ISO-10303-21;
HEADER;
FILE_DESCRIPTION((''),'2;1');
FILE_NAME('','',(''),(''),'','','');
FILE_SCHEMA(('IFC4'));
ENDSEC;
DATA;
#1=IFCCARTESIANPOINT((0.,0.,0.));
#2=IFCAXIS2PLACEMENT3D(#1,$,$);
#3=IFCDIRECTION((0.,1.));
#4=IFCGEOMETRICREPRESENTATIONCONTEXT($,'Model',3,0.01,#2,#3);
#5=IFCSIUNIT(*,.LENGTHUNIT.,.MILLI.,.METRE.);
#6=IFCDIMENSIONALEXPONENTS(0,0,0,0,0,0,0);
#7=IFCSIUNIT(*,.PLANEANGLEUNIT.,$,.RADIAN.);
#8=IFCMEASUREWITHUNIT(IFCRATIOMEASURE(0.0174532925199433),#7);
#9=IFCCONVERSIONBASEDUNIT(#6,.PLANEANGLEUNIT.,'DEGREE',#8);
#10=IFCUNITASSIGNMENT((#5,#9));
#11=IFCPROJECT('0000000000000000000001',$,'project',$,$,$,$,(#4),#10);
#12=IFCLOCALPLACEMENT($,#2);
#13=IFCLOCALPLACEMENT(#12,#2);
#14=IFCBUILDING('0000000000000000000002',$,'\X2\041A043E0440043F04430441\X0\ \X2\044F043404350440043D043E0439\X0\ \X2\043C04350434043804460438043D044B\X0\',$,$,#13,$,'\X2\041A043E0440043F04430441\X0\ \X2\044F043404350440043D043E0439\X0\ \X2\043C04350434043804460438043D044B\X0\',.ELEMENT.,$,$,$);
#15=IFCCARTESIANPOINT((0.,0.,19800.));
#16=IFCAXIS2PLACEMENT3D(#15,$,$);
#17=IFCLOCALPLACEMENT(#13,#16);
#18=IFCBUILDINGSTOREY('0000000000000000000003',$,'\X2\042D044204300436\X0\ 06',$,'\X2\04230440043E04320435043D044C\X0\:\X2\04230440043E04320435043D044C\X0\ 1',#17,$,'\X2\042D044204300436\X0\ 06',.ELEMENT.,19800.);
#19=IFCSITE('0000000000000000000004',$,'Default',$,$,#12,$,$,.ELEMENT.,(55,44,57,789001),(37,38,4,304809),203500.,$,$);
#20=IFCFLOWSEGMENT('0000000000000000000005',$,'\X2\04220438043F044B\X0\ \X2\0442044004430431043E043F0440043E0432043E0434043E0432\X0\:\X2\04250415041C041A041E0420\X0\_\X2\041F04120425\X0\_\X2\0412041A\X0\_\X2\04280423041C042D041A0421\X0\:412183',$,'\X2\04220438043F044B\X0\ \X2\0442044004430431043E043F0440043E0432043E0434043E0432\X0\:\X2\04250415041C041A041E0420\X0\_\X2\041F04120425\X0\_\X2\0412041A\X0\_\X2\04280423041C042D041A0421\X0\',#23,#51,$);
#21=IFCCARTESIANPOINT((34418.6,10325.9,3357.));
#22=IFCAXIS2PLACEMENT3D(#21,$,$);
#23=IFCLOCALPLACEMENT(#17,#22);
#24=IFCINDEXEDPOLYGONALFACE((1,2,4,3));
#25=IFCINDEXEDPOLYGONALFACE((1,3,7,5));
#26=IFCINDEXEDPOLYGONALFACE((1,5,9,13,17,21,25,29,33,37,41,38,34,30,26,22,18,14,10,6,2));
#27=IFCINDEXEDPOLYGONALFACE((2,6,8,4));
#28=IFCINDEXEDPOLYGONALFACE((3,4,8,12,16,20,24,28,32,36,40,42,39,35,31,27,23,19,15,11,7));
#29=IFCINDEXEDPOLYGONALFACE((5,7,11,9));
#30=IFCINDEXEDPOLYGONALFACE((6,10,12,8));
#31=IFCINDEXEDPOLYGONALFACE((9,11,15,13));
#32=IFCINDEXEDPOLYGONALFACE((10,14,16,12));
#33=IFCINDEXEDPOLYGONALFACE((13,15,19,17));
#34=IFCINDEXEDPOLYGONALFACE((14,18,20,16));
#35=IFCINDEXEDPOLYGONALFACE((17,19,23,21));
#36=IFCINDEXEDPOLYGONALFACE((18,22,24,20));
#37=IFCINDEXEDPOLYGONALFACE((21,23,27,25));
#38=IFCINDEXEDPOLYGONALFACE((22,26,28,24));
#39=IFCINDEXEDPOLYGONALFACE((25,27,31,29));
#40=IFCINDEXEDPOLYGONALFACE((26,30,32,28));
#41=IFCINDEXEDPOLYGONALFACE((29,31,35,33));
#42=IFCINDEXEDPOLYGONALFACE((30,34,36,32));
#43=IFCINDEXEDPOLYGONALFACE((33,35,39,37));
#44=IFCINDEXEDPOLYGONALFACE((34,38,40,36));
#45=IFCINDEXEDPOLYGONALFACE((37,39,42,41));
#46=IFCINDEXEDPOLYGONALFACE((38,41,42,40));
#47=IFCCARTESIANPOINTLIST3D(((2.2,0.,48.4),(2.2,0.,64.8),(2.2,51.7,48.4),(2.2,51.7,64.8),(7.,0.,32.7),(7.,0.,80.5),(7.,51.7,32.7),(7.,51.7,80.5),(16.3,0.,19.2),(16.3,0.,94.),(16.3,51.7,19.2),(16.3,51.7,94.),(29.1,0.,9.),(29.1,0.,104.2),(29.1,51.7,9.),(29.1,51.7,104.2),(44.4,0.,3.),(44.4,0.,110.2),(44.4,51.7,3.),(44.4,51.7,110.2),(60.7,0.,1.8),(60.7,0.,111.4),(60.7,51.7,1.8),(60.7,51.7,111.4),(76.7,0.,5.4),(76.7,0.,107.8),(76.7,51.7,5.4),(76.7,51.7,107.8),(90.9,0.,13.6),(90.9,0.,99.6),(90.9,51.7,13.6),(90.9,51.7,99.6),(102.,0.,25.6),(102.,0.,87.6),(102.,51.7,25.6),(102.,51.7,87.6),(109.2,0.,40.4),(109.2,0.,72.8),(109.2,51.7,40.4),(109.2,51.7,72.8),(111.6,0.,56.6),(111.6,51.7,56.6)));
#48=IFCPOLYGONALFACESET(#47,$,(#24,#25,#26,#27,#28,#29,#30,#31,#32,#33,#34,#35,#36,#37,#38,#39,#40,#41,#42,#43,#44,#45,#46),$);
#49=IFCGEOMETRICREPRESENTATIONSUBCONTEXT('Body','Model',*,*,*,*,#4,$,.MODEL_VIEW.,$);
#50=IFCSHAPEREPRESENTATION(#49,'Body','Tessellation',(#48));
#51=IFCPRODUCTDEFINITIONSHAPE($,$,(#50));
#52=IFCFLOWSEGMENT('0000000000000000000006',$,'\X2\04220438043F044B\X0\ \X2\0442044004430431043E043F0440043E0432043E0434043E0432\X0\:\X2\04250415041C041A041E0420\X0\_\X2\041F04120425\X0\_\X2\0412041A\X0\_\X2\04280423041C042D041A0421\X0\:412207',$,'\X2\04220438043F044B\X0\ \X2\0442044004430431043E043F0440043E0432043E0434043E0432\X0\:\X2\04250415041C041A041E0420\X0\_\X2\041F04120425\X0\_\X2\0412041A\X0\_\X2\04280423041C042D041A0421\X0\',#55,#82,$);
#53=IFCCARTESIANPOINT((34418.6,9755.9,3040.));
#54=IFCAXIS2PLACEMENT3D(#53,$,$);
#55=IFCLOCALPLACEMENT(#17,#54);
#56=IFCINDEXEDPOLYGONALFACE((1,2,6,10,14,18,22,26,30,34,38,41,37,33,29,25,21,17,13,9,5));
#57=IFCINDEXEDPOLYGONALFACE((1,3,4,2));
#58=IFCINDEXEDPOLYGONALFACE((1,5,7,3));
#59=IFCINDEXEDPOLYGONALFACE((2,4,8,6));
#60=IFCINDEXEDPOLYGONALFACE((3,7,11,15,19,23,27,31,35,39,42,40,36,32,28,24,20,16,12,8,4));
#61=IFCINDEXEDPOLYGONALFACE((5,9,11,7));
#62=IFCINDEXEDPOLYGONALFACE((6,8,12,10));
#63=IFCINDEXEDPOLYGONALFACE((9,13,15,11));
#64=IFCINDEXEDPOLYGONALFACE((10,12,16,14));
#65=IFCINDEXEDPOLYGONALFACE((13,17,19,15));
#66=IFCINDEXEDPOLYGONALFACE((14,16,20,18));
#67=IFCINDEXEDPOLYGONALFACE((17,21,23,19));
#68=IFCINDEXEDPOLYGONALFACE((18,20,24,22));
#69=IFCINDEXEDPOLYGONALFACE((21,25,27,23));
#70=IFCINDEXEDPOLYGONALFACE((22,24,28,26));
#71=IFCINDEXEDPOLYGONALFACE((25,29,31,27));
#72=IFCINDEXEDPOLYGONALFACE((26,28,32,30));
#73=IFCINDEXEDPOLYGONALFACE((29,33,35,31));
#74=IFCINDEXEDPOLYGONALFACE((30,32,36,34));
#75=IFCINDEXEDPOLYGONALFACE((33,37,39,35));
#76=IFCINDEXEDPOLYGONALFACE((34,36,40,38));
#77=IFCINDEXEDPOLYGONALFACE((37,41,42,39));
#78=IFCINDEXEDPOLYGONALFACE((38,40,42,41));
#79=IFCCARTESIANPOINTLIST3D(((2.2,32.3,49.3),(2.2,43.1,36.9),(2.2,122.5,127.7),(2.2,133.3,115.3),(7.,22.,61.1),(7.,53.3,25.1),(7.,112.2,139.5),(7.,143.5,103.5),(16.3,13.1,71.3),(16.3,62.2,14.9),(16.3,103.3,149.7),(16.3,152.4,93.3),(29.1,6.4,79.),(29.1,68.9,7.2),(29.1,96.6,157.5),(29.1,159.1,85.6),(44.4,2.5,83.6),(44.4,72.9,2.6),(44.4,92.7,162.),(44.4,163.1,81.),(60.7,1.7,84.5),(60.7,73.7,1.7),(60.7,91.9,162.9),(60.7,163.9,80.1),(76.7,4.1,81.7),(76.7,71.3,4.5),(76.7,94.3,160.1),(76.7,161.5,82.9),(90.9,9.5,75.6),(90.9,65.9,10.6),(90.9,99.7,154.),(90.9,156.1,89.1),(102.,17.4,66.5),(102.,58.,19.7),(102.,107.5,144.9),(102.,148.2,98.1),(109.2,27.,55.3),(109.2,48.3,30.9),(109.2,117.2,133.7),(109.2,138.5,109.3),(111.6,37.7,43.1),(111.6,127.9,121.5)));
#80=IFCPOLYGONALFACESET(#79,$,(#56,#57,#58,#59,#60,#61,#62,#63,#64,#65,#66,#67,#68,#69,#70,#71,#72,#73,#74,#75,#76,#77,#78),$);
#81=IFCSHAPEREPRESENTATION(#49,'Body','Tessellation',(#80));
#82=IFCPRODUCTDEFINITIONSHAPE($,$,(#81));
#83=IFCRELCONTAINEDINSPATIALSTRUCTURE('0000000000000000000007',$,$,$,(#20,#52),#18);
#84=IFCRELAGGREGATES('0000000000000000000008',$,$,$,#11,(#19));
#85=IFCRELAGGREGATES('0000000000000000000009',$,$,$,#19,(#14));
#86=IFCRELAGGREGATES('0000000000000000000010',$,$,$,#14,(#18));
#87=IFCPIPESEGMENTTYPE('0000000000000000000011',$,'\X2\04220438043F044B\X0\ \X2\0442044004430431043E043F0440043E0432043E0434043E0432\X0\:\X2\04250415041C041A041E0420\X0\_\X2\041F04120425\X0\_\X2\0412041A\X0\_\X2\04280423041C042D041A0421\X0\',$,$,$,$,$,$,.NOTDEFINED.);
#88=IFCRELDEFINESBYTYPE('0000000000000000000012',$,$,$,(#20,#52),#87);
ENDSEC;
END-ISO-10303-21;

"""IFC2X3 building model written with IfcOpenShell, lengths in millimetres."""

from ifc_helpers import new_model, entity, si_unit, converted_unit, direction, frame, origin, origin_2d_with_axis, place, context, subcontext, project, spatial, circle, extrude, type_object, element, save


model = new_model("IFC2X3")

# Units and contexts
model_context = context("Model", 3, precision=0.01, world=origin(), true_north=direction((0.0, 1.0)))
body_context = subcontext(model_context, "Body", "Model", "MODEL_VIEW")
ifc_project = project(units=[si_unit("LENGTHUNIT", "METRE", prefix="MILLI"), converted_unit("PLANEANGLEUNIT", "DEGREE", entity("IfcRatioMeasure", 0.0174532925199433), si_unit("PLANEANGLEUNIT", "RADIAN"), dimensions=[0, 0, 0, 0, 0, 0, 0])], contexts=[model_context])

# Site, building, storey
site_placement = place(None, origin())
site = spatial("IfcSite", under=ifc_project, at=site_placement, Name="Default", CompositionType="ELEMENT", RefLatitude=(55, 44, 57, 789001), RefLongitude=(37, 38, 4, 304809), RefElevation=203500.0)
building_placement = place(site_placement, origin())
building = spatial("IfcBuilding", under=site, at=building_placement, Name="Корпус ядерной медицины", LongName="Корпус ядерной медицины", CompositionType="ELEMENT")
storey_placement = place(building_placement, frame((0.0, 0.0, 19800.0)))
storey = spatial("IfcBuildingStorey", under=building, at=storey_placement, Name="Этаж 06", ObjectType="Уровень:Уровень 1", LongName="Этаж 06", CompositionType="ELEMENT", Elevation=19800.0)

# Flow segments
pipe_segment_type = type_object("IfcPipeSegmentType", Name="Типы трубопроводов:ХЕМКОР_ПВХ_ВК_ШУМЭКС", PredefinedType="NOTDEFINED")
flow_segment_1_placement = place(storey_placement, frame((34418.6, 10325.9, 3357.0)))
element("IfcFlowSegment", 1, at=flow_segment_1_placement, inside=storey, type_object=pipe_segment_type, Name="Типы трубопроводов:ХЕМКОР_ПВХ_ВК_ШУМЭКС:412183", ObjectType="Типы трубопроводов:ХЕМКОР_ПВХ_ВК_ШУМЭКС", context=body_context, shape_type="SweptSolid", body=[
    extrude(circle(Radius=55.0, at=origin_2d_with_axis()), frame((56.6, 0.0, 56.6), z_axis=(0.0, 1.0, 0.0), x_axis=(1.0, 0.0, 0.0)), (0.0, 0.0, 1.0), 51.7),
])
flow_segment_2_placement = place(storey_placement, frame((34418.6, 9755.9, 3040.0)))
element("IfcFlowSegment", 2, at=flow_segment_2_placement, inside=storey, type_object=pipe_segment_type, Name="Типы трубопроводов:ХЕМКОР_ПВХ_ВК_ШУМЭКС:412207", ObjectType="Типы трубопроводов:ХЕМКОР_ПВХ_ВК_ШУМЭКС", context=body_context, shape_type="SweptSolid", body=[
    extrude(circle(Radius=55.0, at=origin_2d_with_axis()), frame((56.6, 37.7, 43.1), z_axis=(0.0, 0.75471, 0.656059), x_axis=(1.0, 0.0, 0.0)), (0.0, 0.0, 1.0), 119.5),
])

save(model, "model.ifc")
